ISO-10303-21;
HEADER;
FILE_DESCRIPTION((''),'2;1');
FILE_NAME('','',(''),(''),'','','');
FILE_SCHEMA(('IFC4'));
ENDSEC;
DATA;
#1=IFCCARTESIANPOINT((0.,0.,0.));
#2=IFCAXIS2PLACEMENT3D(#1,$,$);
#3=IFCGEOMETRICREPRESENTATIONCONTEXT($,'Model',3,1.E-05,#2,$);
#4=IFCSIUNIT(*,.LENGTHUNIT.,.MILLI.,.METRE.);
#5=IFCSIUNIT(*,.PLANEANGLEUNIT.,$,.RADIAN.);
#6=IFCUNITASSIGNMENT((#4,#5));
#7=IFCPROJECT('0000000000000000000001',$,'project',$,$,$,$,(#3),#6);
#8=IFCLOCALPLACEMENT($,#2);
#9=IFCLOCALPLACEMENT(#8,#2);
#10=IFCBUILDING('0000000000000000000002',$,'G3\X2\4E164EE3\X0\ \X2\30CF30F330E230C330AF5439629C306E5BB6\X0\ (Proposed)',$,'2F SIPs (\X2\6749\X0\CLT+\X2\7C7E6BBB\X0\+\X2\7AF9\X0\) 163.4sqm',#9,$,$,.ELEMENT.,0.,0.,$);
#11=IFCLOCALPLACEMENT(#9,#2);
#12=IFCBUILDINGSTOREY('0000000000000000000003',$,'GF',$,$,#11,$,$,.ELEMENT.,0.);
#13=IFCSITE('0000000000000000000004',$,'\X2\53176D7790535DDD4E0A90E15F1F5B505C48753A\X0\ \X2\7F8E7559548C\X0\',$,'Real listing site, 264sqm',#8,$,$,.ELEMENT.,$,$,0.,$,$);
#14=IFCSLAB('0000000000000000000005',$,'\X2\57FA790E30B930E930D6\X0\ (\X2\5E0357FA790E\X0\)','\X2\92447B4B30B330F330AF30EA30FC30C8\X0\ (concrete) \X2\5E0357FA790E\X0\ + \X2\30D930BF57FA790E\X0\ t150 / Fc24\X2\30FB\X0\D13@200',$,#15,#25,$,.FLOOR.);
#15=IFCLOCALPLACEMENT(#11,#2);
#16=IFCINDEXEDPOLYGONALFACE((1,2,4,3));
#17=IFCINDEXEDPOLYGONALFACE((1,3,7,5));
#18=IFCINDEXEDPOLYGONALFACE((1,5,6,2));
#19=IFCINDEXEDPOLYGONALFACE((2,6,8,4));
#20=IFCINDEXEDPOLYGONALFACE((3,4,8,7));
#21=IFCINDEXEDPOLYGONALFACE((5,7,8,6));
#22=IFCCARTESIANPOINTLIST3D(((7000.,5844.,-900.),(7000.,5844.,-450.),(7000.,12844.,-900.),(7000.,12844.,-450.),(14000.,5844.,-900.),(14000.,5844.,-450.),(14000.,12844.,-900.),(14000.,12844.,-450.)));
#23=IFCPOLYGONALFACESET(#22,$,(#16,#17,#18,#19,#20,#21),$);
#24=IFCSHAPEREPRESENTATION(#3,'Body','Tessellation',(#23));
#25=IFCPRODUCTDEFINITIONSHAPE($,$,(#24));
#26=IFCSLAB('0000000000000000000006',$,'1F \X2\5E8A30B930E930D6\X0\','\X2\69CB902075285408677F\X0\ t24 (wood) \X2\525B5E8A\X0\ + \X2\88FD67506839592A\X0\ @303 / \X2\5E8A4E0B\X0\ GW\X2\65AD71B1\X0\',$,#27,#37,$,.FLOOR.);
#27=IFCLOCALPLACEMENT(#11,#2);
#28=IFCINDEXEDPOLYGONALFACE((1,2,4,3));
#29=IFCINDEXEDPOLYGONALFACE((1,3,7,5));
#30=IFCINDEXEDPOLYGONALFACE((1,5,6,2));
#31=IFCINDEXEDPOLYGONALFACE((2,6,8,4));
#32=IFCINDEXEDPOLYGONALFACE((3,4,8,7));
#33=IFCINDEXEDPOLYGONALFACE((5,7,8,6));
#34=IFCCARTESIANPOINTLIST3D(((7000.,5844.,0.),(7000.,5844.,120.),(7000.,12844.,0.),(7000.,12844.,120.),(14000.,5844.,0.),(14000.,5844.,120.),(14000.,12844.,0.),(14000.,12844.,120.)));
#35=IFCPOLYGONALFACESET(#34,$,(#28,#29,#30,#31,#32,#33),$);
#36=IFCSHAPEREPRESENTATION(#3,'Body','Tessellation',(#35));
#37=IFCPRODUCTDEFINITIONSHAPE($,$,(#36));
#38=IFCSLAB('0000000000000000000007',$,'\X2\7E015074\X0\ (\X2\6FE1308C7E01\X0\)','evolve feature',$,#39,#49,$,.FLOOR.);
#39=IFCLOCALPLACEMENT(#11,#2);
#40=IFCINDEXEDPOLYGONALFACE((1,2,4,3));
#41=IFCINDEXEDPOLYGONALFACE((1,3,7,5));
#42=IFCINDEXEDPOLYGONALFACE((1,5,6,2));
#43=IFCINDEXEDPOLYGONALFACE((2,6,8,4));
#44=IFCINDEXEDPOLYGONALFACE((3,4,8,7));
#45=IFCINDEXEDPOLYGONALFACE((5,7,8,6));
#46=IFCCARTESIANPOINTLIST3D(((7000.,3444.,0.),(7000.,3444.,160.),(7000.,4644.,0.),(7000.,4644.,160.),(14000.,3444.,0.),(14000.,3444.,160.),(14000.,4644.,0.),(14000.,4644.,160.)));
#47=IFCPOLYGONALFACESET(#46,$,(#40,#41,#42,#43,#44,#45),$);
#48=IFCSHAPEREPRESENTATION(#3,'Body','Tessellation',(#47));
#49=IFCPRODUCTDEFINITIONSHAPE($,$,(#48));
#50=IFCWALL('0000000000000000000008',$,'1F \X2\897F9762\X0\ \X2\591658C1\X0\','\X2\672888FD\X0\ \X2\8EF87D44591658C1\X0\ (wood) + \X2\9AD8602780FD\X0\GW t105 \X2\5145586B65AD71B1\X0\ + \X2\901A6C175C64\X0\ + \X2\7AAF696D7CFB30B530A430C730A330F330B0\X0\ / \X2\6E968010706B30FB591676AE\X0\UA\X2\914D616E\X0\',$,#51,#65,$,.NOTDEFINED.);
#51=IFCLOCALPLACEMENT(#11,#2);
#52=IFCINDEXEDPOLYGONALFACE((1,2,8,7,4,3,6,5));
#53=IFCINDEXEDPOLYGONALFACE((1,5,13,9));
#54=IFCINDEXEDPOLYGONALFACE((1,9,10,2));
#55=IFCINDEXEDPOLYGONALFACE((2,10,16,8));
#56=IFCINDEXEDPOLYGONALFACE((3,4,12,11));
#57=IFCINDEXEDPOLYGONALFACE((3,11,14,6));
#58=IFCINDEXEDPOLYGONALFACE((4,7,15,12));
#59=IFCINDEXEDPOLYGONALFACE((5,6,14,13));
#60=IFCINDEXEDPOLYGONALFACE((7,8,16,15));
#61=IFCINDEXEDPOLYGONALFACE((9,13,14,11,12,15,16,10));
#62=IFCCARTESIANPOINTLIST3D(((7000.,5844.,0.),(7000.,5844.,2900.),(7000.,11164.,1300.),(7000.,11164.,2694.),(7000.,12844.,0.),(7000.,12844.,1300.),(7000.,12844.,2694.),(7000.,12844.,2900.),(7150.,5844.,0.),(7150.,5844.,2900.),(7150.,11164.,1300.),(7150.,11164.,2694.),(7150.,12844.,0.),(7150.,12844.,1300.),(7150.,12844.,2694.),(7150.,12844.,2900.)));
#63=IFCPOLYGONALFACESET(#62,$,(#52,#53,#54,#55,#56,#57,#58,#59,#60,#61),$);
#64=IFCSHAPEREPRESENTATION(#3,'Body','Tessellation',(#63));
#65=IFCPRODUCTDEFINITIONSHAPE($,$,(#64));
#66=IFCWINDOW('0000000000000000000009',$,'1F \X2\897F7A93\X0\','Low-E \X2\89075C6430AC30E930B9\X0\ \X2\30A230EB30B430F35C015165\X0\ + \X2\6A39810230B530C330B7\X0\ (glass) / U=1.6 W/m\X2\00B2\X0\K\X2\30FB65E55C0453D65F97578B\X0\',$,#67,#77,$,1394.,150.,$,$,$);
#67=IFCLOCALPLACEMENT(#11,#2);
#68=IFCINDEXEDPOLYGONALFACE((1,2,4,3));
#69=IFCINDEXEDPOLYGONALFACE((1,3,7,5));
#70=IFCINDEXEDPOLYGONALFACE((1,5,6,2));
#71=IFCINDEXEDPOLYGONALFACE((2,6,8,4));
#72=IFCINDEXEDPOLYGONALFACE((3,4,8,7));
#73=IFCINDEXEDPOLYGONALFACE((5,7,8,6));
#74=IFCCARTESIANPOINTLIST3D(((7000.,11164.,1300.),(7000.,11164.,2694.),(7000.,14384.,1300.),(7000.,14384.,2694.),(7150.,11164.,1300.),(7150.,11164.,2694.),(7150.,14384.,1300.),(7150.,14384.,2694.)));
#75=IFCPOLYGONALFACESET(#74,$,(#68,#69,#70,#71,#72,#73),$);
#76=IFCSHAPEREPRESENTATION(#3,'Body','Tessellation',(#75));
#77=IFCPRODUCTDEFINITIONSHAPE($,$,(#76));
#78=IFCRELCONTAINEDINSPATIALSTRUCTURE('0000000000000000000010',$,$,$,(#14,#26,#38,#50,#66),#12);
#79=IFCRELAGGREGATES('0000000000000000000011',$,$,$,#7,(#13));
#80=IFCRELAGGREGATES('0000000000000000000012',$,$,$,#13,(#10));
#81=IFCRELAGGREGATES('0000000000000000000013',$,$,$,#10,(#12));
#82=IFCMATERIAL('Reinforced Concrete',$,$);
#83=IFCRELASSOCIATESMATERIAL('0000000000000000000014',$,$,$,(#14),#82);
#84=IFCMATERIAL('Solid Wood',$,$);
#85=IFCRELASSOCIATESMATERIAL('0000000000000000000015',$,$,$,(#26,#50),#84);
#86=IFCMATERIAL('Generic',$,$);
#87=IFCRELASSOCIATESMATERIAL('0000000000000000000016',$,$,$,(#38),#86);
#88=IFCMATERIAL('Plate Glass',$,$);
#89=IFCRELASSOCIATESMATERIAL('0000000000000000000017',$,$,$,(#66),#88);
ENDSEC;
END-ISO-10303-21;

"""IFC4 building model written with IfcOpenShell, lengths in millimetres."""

from ifc_helpers import new_model, si_unit, frame, frame_2d, origin, place, context, project, spatial, rectangle, extrude, material, element, fill, save


model = new_model("IFC4")

# Units and contexts
model_context = context("Model", 3, precision=1e-05, world=origin())
ifc_project = project(units=[si_unit("LENGTHUNIT", "METRE", prefix="MILLI"), si_unit("PLANEANGLEUNIT", "RADIAN")], contexts=[model_context])

# Site, building, storey
site_placement = place(None, origin())
site = spatial("IfcSite", under=ifc_project, at=site_placement, Name="北海道川上郡弟子屈町 美留和", ObjectType="Real listing site, 264sqm", CompositionType="ELEMENT", RefElevation=0.0)
building_placement = place(site_placement, origin())
building = spatial("IfcBuilding", under=site, at=building_placement, Name="G3世代 ハンモック吹抜の家 (Proposed)", ObjectType="2F SIPs (杉CLT+籾殻+竹) 163.4sqm", CompositionType="ELEMENT", ElevationOfRefHeight=0.0, ElevationOfTerrain=0.0)
storey_placement = place(building_placement, origin())
storey = spatial("IfcBuildingStorey", under=building, at=storey_placement, Name="GF", CompositionType="ELEMENT", Elevation=0.0)

# Slabs
ifc_material_1 = material(Name="Reinforced Concrete")
slab_1_placement = place(storey_placement, frame((3500.0, 2922.0, -450.0)))
element("IfcSlab", 1, at=slab_1_placement, inside=storey, material=ifc_material_1, Name="基礎スラブ (布基礎)", Description="鉄筋コンクリート (concrete) 布基礎 + ベタ基礎 t150 / Fc24・D13@200", PredefinedType="FLOOR", context=model_context, shape_type="SweptSolid", body=[
    extrude(rectangle(XDim=7000.0, YDim=7000.0, at=frame_2d((3500.0, 3500.0))), frame((3500.0, 2922.0, -450.0)), (0.0, 0.0, 1.0), 450.0),
])
ifc_material_2 = material(Name="Solid Wood")
slab_2_placement = place(storey_placement, frame((3500.0, 2922.0, 0.0)))
element("IfcSlab", 2, at=slab_2_placement, inside=storey, material=ifc_material_2, Name="1F 床スラブ", Description="構造用合板 t24 (wood) 剛床 + 製材根太 @303 / 床下 GW断熱", PredefinedType="FLOOR", context=model_context, shape_type="SweptSolid", body=[
    extrude(rectangle(XDim=7000.0, YDim=7000.0, at=frame_2d((3500.0, 3500.0))), frame((3500.0, 2922.0, 0.0)), (0.0, 0.0, 1.0), 120.0),
])
ifc_material_3 = material(Name="Generic")
slab_3_placement = place(storey_placement, frame((3500.0, 1722.0, 0.0)))
element("IfcSlab", 3, at=slab_3_placement, inside=storey, material=ifc_material_3, Name="縁側 (濡れ縁)", Description="evolve feature", PredefinedType="FLOOR", context=model_context, shape_type="SweptSolid", body=[
    extrude(rectangle(XDim=7000.0, YDim=1200.0, at=frame_2d((3500.0, 600.0))), frame((3500.0, 1722.0, 0.0)), (0.0, 0.0, 1.0), 160.0),
])

# Shared definitions
ifc_material_4 = material(Name="Plate Glass")

# Wall, opening, window
wall_1_placement = place(storey_placement, frame((3500.0, 2922.0, 0.0)))
wall_1 = element("IfcWall", 4, at=wall_1_placement, inside=storey, material=ifc_material_2, Name="1F 西面 外壁", Description="木製 軸組外壁 (wood) + 高性能GW t105 充填断熱 + 通気層 + 窯業系サイディング / 準耐火・外皮UA配慮", PredefinedType="NOTDEFINED", context=model_context, shape_type="SweptSolid", body=[
    extrude(rectangle(XDim=150.0, YDim=7000.0, at=frame_2d((75.0, 3500.0))), frame((3500.0, 2922.0, 0.0)), (0.0, 0.0, 1.0), 2900.0),
])
opening_1_placement = place(storey_placement, frame((3500.0, 5582.0, 650.0)))
opening_1 = element("IfcOpeningElement", 5, at=opening_1_placement, cuts=wall_1, PredefinedType="NOTDEFINED", context=model_context, shape_type="SweptSolid", body=[
    extrude(rectangle(XDim=150.0, YDim=3220.0, at=frame_2d((75.0, 1610.0))), frame((3500.0, 5582.0, 650.0)), (0.0, 0.0, 1.0), 1394.0),
])
window_1_placement = place(storey_placement, frame((3500.0, 5582.0, 650.0)))
window_1 = element("IfcWindow", 6, at=window_1_placement, inside=storey, material=ifc_material_4, Name="1F 西窓", Description="Low-E 複層ガラス アルゴン封入 + 樹脂サッシ (glass) / U=1.6 W/m²K・日射取得型", OverallHeight=1394.0, OverallWidth=150.0, context=model_context, shape_type="SweptSolid", body=[
    extrude(rectangle(XDim=150.0, YDim=3220.0, at=frame_2d((75.0, 1610.0))), frame((3500.0, 5582.0, 650.0)), (0.0, 0.0, 1.0), 1394.0),
])
fill(opening_1, window_1)

save(model, "model.ifc")
